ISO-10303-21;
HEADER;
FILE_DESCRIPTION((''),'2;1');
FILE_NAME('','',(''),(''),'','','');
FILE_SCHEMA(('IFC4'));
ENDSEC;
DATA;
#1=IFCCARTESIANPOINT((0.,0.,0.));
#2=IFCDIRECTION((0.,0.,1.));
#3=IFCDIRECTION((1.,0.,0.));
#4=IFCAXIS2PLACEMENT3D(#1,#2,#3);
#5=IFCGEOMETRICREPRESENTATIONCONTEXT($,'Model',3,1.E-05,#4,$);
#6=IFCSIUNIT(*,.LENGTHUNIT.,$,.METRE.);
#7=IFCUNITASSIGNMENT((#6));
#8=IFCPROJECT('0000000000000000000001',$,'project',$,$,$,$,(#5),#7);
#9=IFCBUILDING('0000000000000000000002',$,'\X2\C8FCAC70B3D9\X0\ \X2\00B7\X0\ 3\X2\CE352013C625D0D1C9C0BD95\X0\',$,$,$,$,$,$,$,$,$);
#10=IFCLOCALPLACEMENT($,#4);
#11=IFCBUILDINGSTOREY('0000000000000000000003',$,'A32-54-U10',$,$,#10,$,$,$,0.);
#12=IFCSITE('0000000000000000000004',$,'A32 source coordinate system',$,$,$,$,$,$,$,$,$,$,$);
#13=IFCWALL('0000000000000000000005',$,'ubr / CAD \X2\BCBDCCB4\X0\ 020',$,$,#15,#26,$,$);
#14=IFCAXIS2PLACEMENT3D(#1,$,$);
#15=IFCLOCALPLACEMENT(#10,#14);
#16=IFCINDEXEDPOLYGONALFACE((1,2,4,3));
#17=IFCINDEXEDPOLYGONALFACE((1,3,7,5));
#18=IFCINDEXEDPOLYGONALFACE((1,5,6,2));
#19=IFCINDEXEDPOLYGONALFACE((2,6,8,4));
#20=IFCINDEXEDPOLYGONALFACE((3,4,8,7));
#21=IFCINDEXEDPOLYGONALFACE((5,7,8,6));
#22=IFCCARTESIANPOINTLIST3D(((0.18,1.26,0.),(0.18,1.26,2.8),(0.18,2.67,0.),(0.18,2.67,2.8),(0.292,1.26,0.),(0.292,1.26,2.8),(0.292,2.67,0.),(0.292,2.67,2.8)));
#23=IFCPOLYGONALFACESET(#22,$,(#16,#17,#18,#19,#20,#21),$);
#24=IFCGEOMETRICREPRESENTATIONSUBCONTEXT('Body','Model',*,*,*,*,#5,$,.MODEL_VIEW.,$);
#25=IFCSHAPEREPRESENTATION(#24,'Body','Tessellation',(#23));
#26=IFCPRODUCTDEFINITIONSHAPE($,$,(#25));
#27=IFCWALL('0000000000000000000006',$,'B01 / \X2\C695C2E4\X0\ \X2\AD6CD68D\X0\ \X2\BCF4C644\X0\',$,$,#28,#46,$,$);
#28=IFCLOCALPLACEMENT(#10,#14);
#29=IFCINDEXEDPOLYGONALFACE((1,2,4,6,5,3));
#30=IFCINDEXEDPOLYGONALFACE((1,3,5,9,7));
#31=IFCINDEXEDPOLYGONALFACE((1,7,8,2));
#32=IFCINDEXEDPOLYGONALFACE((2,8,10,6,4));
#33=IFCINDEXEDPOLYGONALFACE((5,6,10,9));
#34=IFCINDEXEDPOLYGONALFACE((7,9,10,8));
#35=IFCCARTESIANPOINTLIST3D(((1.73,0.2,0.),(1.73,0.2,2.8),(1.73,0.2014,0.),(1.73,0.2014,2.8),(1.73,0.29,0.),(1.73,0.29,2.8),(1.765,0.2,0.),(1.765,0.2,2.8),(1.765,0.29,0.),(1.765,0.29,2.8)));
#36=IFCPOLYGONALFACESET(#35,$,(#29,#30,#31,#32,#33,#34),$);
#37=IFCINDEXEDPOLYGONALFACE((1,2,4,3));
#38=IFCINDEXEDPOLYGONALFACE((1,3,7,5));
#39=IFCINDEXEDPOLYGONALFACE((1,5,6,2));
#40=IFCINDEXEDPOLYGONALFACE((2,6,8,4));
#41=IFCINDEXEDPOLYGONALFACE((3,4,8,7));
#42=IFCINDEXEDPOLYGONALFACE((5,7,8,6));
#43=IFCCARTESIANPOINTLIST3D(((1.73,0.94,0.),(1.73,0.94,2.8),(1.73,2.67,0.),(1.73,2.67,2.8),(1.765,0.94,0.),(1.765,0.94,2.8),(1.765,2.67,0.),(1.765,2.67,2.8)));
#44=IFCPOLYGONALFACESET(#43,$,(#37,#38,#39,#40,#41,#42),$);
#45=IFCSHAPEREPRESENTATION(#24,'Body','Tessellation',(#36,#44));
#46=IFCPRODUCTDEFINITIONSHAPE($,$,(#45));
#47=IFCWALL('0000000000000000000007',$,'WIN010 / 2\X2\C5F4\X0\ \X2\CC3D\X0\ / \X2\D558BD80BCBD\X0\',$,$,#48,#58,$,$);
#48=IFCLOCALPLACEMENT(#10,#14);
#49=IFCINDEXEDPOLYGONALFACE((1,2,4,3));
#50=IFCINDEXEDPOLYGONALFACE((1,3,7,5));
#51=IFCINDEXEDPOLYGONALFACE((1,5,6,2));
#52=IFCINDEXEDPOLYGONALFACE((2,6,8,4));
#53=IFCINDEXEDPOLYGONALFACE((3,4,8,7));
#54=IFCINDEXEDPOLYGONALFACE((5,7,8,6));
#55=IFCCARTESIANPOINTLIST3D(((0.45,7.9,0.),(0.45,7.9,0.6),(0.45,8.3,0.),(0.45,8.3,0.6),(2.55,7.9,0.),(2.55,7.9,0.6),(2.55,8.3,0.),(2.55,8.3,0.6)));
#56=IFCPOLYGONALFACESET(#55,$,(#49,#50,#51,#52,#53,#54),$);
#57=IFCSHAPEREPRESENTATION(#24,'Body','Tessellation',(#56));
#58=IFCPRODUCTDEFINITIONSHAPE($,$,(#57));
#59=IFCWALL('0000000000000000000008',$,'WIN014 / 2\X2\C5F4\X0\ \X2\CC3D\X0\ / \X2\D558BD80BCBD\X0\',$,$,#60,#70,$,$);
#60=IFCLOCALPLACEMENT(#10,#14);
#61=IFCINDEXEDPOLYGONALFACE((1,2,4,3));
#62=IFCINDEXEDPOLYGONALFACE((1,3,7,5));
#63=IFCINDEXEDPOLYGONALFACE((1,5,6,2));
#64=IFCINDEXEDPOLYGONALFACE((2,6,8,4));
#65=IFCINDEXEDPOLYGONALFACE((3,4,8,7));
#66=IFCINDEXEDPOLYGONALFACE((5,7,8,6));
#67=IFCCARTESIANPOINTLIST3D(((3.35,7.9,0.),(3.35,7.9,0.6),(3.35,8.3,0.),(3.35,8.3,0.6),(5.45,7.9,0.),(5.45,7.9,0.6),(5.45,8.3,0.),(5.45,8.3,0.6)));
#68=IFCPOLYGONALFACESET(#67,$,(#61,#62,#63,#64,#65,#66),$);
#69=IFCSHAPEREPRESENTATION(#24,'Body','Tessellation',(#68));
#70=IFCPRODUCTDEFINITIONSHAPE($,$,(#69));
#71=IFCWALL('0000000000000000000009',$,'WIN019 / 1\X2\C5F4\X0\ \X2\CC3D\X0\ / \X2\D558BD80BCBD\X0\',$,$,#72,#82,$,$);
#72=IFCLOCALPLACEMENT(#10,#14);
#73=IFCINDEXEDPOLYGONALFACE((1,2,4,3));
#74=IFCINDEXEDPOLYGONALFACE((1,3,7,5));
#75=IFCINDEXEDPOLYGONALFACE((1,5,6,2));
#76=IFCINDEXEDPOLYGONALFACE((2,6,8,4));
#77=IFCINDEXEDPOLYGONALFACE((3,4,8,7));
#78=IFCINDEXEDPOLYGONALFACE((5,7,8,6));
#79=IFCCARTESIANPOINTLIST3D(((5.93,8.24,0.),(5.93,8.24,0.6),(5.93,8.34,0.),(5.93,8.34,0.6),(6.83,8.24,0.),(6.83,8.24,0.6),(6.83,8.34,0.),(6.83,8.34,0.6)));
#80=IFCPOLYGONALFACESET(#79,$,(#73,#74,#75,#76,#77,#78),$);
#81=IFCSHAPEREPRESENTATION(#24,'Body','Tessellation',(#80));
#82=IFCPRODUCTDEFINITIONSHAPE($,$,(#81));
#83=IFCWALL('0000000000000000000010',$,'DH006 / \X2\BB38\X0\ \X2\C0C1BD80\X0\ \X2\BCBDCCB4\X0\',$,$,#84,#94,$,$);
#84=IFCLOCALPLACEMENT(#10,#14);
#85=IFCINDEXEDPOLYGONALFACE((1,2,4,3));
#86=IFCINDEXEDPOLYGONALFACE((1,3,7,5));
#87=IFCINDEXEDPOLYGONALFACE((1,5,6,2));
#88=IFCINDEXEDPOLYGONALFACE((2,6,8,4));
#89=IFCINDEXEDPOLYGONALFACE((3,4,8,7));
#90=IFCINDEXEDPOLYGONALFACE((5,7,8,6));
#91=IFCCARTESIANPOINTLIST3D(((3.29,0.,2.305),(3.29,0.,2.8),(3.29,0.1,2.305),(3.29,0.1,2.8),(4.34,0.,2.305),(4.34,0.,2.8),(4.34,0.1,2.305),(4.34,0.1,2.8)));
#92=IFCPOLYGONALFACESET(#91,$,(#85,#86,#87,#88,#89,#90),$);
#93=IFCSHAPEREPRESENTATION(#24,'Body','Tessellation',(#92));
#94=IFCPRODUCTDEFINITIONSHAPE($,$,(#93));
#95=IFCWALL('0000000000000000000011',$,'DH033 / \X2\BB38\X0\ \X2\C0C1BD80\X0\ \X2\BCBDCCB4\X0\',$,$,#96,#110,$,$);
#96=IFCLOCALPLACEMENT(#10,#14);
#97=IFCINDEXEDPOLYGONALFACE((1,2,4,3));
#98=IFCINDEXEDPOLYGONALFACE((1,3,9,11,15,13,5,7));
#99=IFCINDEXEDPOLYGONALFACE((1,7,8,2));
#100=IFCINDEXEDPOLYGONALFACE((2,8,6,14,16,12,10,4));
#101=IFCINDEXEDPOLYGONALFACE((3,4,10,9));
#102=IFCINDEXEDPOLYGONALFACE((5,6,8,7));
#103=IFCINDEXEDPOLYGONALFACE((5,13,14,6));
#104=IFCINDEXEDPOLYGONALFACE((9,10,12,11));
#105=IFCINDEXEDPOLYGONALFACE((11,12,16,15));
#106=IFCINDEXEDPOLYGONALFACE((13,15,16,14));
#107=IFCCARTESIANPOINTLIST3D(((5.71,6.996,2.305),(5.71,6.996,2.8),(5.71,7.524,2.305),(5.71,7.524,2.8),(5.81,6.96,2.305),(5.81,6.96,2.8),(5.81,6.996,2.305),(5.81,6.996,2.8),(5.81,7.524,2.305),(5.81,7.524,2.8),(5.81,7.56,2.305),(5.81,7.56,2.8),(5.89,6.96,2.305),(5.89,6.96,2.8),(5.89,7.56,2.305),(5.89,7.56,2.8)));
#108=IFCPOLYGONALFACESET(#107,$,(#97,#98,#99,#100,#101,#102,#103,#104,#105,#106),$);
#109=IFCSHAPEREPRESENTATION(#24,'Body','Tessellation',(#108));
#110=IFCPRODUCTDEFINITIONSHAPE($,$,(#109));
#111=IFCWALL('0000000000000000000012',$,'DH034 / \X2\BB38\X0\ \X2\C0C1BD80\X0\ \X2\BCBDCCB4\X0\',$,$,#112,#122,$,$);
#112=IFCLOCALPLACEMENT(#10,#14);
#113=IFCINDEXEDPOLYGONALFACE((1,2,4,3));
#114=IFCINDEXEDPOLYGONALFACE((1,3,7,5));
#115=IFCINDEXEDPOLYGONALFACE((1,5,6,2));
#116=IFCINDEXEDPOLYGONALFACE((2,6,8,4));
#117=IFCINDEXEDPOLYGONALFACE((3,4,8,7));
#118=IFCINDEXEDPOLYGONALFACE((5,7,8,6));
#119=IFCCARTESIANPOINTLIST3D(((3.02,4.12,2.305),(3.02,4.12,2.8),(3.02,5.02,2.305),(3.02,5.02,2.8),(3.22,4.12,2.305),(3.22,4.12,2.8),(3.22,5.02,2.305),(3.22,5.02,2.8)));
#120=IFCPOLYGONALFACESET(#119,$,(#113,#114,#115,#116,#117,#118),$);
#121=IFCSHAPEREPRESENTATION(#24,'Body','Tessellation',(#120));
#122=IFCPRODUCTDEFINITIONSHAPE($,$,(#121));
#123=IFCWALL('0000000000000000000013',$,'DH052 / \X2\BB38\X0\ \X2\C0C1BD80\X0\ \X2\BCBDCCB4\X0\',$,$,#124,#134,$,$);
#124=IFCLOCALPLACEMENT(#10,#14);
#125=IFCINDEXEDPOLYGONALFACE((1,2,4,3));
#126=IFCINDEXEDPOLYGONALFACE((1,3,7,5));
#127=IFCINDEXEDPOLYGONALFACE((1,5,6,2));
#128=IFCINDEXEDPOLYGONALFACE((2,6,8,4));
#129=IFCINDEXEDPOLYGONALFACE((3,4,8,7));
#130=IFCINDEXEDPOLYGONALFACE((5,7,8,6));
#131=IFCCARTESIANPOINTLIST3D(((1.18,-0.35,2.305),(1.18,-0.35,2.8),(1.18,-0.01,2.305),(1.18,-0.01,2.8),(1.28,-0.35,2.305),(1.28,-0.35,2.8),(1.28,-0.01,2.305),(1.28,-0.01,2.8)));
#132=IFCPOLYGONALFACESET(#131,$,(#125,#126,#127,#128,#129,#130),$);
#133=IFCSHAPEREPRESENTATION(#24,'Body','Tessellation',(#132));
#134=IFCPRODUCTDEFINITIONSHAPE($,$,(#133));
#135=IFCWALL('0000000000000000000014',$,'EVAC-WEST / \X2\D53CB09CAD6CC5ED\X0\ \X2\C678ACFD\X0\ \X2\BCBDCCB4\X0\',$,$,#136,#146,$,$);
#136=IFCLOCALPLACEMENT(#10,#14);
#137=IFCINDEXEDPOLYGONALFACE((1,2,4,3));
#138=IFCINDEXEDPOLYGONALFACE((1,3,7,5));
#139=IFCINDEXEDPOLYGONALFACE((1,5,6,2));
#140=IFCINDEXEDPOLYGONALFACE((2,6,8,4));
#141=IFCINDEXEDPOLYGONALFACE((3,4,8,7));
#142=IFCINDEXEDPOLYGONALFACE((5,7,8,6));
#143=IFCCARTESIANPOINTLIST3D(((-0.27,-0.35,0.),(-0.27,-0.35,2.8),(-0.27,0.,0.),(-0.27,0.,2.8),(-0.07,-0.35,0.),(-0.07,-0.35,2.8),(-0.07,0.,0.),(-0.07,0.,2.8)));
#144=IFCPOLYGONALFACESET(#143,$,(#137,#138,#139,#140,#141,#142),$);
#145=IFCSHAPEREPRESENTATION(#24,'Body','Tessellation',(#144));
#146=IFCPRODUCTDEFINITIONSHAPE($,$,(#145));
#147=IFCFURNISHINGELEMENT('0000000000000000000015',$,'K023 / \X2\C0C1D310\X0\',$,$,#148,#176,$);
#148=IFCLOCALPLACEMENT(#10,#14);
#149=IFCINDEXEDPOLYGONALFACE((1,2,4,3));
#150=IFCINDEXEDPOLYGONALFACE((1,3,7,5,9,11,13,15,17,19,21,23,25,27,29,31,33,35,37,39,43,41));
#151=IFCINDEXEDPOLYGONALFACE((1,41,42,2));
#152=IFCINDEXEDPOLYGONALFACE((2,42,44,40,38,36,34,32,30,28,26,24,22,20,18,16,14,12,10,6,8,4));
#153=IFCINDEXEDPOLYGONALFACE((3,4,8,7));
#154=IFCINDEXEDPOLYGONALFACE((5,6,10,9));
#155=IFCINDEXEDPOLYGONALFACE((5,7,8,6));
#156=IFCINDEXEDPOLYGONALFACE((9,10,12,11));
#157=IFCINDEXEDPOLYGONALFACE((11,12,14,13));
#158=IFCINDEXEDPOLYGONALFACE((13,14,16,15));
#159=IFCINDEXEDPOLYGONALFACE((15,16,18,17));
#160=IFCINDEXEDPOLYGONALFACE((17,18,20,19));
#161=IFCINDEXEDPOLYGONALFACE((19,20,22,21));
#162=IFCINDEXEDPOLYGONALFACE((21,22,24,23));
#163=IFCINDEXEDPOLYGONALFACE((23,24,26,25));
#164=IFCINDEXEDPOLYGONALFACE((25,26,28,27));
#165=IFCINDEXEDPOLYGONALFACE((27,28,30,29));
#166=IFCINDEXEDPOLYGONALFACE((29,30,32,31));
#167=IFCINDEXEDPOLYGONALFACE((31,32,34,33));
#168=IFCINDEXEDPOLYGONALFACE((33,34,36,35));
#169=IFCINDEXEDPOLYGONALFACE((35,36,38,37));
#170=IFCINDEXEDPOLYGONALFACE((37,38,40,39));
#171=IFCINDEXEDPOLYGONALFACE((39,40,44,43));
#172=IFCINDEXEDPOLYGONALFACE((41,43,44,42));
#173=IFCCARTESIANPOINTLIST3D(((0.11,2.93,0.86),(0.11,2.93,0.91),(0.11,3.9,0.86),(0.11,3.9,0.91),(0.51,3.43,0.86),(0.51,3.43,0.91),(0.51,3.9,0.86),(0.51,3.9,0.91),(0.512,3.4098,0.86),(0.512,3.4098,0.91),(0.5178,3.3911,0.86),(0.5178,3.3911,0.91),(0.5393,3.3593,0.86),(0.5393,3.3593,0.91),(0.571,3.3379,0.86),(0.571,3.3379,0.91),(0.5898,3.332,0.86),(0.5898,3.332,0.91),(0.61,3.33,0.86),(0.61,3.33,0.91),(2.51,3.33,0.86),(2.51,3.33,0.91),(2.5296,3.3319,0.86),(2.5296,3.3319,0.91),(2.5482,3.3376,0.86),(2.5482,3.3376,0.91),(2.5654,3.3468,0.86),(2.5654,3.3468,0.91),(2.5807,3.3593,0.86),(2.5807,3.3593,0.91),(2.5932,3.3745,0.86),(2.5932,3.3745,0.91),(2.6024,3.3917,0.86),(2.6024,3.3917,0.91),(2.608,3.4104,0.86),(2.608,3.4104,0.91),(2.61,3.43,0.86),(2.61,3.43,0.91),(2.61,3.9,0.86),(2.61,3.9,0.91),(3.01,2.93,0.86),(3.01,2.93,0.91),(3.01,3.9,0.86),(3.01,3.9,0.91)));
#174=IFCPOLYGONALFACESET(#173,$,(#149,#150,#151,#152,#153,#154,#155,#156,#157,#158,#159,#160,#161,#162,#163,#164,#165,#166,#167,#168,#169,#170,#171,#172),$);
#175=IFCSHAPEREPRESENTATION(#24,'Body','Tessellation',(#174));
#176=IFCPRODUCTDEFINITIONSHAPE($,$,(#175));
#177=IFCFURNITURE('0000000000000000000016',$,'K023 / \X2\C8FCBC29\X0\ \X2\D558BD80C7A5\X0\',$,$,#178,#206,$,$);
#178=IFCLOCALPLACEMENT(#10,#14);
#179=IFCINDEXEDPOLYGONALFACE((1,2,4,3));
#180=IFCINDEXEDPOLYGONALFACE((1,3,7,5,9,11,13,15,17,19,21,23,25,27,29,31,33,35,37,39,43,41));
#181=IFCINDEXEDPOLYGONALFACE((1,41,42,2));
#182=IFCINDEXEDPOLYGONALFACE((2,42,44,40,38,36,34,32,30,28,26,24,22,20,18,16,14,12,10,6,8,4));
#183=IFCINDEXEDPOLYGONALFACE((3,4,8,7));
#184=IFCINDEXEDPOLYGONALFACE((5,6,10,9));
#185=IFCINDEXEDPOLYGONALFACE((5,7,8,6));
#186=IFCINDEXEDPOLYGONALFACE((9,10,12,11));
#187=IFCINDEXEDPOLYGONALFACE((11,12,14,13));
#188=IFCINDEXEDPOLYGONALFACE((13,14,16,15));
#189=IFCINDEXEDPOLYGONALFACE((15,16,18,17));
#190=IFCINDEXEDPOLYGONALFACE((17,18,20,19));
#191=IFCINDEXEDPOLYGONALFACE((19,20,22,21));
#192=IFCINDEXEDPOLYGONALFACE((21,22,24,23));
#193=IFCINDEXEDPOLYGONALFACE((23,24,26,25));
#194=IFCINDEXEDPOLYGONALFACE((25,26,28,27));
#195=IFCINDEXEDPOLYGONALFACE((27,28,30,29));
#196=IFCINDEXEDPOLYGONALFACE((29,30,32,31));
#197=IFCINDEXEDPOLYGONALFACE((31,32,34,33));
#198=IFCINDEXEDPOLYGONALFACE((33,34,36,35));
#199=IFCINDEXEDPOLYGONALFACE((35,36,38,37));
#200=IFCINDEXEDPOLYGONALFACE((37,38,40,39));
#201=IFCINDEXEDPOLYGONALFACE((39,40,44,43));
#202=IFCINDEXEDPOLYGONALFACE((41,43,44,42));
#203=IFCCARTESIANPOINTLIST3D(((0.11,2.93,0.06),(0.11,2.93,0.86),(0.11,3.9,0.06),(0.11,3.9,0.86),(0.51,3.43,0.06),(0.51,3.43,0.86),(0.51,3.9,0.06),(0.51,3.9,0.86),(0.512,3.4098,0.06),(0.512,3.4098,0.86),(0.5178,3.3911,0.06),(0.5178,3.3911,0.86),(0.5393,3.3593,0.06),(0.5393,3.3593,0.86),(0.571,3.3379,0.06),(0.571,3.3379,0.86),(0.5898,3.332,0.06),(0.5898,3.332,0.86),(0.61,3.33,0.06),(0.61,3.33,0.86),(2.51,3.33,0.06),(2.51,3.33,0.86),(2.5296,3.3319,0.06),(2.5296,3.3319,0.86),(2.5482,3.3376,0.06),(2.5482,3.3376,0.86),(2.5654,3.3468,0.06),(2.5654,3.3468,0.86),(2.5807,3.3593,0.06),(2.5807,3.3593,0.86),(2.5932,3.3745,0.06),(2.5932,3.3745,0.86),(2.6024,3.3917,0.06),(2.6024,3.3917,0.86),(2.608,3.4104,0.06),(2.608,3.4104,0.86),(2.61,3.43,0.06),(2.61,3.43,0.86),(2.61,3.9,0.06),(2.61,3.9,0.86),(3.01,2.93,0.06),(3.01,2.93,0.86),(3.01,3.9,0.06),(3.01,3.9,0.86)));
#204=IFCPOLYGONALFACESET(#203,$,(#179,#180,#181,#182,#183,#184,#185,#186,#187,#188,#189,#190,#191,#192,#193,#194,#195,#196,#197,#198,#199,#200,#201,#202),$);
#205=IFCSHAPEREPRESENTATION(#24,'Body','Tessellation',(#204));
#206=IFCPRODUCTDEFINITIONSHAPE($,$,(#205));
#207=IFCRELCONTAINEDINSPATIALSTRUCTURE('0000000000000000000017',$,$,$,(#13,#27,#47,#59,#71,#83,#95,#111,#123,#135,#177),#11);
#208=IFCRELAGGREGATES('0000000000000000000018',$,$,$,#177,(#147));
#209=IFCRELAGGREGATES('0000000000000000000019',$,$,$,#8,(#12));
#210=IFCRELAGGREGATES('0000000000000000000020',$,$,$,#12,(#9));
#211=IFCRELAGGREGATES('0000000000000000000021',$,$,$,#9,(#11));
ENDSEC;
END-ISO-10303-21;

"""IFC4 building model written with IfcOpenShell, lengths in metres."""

from ifc_helpers import new_model, si_unit, frame, origin, origin_with_axes, place, context, subcontext, project, spatial, polyline, outline, extrude, element, aggregate, save


model = new_model("IFC4")

# Units and contexts
model_context = context("Model", 3, precision=1e-05, world=origin_with_axes())
body_context = subcontext(model_context, "Body", "Model", "MODEL_VIEW")
ifc_project = project(units=[si_unit("LENGTHUNIT", "METRE")], contexts=[model_context])

# Site, building, storey
site = spatial("IfcSite", under=ifc_project, Name="A32 source coordinate system")
building = spatial("IfcBuilding", under=site, Name="주거동 · 3층–옥탑지붕")
storey_placement = place(None, origin_with_axes())
storey = spatial("IfcBuildingStorey", under=building, at=storey_placement, Name="A32-54-U10", Elevation=0.0)

# Walls
wall_1_placement = place(storey_placement, origin_with_axes())
element("IfcWall", 1, at=wall_1_placement, inside=storey, Name="ubr / CAD 벽체 020", context=body_context, shape_type="SweptSolid", body=[
    extrude(outline(polyline([(0.18, 1.26), (0.18, 2.67), (0.292, 2.67), (0.292, 1.26), (0.18, 1.26)])), origin(), (0.0, 0.0, 1.0), 2.8),
])
wall_2_placement = place(storey_placement, origin_with_axes())
element("IfcWall", 2, at=wall_2_placement, inside=storey, Name="B01 / 욕실 구획 보완", context=body_context, shape_type="SweptSolid", body=[
    extrude(outline(polyline([(1.765, 0.2), (1.73, 0.2), (1.73, 0.2014), (1.73, 0.29), (1.765, 0.29), (1.765, 0.2)])), origin(), (0.0, 0.0, 1.0), 2.8),
    extrude(outline(polyline([(1.765, 2.67), (1.765, 0.94), (1.73, 0.94), (1.73, 2.67), (1.765, 2.67)])), origin(), (0.0, 0.0, 1.0), 2.8),
])
wall_3_placement = place(storey_placement, origin_with_axes())
element("IfcWall", 3, at=wall_3_placement, inside=storey, Name="WIN010 / 2열 창 / 하부벽", context=body_context, shape_type="SweptSolid", body=[
    extrude(outline(polyline([(2.55, 8.3), (2.55, 7.9), (0.45, 7.9), (0.45, 8.3), (2.55, 8.3)])), origin(), (0.0, 0.0, 1.0), 0.6),
])
wall_4_placement = place(storey_placement, origin_with_axes())
element("IfcWall", 4, at=wall_4_placement, inside=storey, Name="WIN014 / 2열 창 / 하부벽", context=body_context, shape_type="SweptSolid", body=[
    extrude(outline(polyline([(5.45, 8.3), (5.45, 7.9), (3.35, 7.9), (3.35, 8.3), (5.45, 8.3)])), origin(), (0.0, 0.0, 1.0), 0.6),
])
wall_5_placement = place(storey_placement, origin_with_axes())
element("IfcWall", 5, at=wall_5_placement, inside=storey, Name="WIN019 / 1열 창 / 하부벽", context=body_context, shape_type="SweptSolid", body=[
    extrude(outline(polyline([(6.83, 8.34), (6.83, 8.24), (5.93, 8.24), (5.93, 8.34), (6.83, 8.34)])), origin(), (0.0, 0.0, 1.0), 0.6),
])
wall_6_placement = place(storey_placement, origin_with_axes())
element("IfcWall", 6, at=wall_6_placement, inside=storey, Name="DH006 / 문 상부 벽체", context=body_context, shape_type="SweptSolid", body=[
    extrude(outline(polyline([(4.34, 0.0), (3.29, 0.0), (3.29, 0.1), (4.34, 0.1), (4.34, 0.0)])), frame((0.0, 0.0, 2.305)), (0.0, 0.0, 1.0), 0.495),
])
wall_7_placement = place(storey_placement, origin_with_axes())
element("IfcWall", 7, at=wall_7_placement, inside=storey, Name="DH033 / 문 상부 벽체", context=body_context, shape_type="SweptSolid", body=[
    extrude(outline(polyline([(5.81, 6.996), (5.71, 6.996), (5.71, 7.524), (5.81, 7.524), (5.81, 7.56), (5.89, 7.56), (5.89, 6.96), (5.81, 6.96), (5.81, 6.996)])), frame((0.0, 0.0, 2.305)), (0.0, 0.0, 1.0), 0.495),
])
wall_8_placement = place(storey_placement, origin_with_axes())
element("IfcWall", 8, at=wall_8_placement, inside=storey, Name="DH034 / 문 상부 벽체", context=body_context, shape_type="SweptSolid", body=[
    extrude(outline(polyline([(3.22, 4.12), (3.02, 4.12), (3.02, 5.02), (3.22, 5.02), (3.22, 4.12)])), frame((0.0, 0.0, 2.305)), (0.0, 0.0, 1.0), 0.495),
])
wall_9_placement = place(storey_placement, origin_with_axes())
element("IfcWall", 9, at=wall_9_placement, inside=storey, Name="DH052 / 문 상부 벽체", context=body_context, shape_type="SweptSolid", body=[
    extrude(outline(polyline([(1.28, -0.35), (1.18, -0.35), (1.18, -0.01), (1.28, -0.01), (1.28, -0.35)])), frame((0.0, 0.0, 2.305)), (0.0, 0.0, 1.0), 0.495),
])
wall_10_placement = place(storey_placement, origin_with_axes())
element("IfcWall", 10, at=wall_10_placement, inside=storey, Name="EVAC-WEST / 피난구역 외곽 벽체", context=body_context, shape_type="SweptSolid", body=[
    extrude(outline(polyline([(-0.07, 0.0), (-0.07, -0.35), (-0.27, -0.35), (-0.27, 0.0), (-0.07, 0.0)])), origin(), (0.0, 0.0, 1.0), 2.8),
])

# Furnishing element
furniture_1_placement = place(storey_placement, origin_with_axes())
furnishing_1_placement = place(furniture_1_placement, origin_with_axes())
furnishing_1 = element("IfcFurnishingElement", 11, at=furnishing_1_placement, Name="K023 / 상판", context=body_context, shape_type="SweptSolid", body=[
    extrude(outline(polyline([(0.51, 3.43), (0.512, 3.4098), (0.5178, 3.3911), (0.5393, 3.3593), (0.571, 3.3379), (0.5898, 3.332), (0.61, 3.33), (2.51, 3.33), (2.5296, 3.3319), (2.5482, 3.3376), (2.5654, 3.3468), (2.5807, 3.3593), (2.5932, 3.3745), (2.6024, 3.3917), (2.608, 3.4104), (2.61, 3.43), (2.61, 3.9), (3.01, 3.9), (3.01, 2.93), (0.11, 2.93), (0.11, 3.9), (0.51, 3.9), (0.51, 3.43)])), frame((0.0, 0.0, 0.86)), (0.0, 0.0, 1.0), 0.05),
])

# Furniture
furniture_1 = element("IfcFurniture", 12, at=furniture_1_placement, inside=storey, Name="K023 / 주방 하부장", context=body_context, shape_type="SweptSolid", body=[
    extrude(outline(polyline([(0.51, 3.9), (0.51, 3.43), (0.512, 3.4098), (0.5178, 3.3911), (0.5393, 3.3593), (0.571, 3.3379), (0.5898, 3.332), (0.61, 3.33), (2.51, 3.33), (2.5296, 3.3319), (2.5482, 3.3376), (2.5654, 3.3468), (2.5807, 3.3593), (2.5932, 3.3745), (2.6024, 3.3917), (2.608, 3.4104), (2.61, 3.43), (2.61, 3.9), (3.01, 3.9), (3.01, 2.93), (0.11, 2.93), (0.11, 3.9), (0.51, 3.9)])), frame((0.0, 0.0, 0.06)), (0.0, 0.0, 1.0), 0.8),
])
aggregate(furniture_1, [furnishing_1])

save(model, "model.ifc")
